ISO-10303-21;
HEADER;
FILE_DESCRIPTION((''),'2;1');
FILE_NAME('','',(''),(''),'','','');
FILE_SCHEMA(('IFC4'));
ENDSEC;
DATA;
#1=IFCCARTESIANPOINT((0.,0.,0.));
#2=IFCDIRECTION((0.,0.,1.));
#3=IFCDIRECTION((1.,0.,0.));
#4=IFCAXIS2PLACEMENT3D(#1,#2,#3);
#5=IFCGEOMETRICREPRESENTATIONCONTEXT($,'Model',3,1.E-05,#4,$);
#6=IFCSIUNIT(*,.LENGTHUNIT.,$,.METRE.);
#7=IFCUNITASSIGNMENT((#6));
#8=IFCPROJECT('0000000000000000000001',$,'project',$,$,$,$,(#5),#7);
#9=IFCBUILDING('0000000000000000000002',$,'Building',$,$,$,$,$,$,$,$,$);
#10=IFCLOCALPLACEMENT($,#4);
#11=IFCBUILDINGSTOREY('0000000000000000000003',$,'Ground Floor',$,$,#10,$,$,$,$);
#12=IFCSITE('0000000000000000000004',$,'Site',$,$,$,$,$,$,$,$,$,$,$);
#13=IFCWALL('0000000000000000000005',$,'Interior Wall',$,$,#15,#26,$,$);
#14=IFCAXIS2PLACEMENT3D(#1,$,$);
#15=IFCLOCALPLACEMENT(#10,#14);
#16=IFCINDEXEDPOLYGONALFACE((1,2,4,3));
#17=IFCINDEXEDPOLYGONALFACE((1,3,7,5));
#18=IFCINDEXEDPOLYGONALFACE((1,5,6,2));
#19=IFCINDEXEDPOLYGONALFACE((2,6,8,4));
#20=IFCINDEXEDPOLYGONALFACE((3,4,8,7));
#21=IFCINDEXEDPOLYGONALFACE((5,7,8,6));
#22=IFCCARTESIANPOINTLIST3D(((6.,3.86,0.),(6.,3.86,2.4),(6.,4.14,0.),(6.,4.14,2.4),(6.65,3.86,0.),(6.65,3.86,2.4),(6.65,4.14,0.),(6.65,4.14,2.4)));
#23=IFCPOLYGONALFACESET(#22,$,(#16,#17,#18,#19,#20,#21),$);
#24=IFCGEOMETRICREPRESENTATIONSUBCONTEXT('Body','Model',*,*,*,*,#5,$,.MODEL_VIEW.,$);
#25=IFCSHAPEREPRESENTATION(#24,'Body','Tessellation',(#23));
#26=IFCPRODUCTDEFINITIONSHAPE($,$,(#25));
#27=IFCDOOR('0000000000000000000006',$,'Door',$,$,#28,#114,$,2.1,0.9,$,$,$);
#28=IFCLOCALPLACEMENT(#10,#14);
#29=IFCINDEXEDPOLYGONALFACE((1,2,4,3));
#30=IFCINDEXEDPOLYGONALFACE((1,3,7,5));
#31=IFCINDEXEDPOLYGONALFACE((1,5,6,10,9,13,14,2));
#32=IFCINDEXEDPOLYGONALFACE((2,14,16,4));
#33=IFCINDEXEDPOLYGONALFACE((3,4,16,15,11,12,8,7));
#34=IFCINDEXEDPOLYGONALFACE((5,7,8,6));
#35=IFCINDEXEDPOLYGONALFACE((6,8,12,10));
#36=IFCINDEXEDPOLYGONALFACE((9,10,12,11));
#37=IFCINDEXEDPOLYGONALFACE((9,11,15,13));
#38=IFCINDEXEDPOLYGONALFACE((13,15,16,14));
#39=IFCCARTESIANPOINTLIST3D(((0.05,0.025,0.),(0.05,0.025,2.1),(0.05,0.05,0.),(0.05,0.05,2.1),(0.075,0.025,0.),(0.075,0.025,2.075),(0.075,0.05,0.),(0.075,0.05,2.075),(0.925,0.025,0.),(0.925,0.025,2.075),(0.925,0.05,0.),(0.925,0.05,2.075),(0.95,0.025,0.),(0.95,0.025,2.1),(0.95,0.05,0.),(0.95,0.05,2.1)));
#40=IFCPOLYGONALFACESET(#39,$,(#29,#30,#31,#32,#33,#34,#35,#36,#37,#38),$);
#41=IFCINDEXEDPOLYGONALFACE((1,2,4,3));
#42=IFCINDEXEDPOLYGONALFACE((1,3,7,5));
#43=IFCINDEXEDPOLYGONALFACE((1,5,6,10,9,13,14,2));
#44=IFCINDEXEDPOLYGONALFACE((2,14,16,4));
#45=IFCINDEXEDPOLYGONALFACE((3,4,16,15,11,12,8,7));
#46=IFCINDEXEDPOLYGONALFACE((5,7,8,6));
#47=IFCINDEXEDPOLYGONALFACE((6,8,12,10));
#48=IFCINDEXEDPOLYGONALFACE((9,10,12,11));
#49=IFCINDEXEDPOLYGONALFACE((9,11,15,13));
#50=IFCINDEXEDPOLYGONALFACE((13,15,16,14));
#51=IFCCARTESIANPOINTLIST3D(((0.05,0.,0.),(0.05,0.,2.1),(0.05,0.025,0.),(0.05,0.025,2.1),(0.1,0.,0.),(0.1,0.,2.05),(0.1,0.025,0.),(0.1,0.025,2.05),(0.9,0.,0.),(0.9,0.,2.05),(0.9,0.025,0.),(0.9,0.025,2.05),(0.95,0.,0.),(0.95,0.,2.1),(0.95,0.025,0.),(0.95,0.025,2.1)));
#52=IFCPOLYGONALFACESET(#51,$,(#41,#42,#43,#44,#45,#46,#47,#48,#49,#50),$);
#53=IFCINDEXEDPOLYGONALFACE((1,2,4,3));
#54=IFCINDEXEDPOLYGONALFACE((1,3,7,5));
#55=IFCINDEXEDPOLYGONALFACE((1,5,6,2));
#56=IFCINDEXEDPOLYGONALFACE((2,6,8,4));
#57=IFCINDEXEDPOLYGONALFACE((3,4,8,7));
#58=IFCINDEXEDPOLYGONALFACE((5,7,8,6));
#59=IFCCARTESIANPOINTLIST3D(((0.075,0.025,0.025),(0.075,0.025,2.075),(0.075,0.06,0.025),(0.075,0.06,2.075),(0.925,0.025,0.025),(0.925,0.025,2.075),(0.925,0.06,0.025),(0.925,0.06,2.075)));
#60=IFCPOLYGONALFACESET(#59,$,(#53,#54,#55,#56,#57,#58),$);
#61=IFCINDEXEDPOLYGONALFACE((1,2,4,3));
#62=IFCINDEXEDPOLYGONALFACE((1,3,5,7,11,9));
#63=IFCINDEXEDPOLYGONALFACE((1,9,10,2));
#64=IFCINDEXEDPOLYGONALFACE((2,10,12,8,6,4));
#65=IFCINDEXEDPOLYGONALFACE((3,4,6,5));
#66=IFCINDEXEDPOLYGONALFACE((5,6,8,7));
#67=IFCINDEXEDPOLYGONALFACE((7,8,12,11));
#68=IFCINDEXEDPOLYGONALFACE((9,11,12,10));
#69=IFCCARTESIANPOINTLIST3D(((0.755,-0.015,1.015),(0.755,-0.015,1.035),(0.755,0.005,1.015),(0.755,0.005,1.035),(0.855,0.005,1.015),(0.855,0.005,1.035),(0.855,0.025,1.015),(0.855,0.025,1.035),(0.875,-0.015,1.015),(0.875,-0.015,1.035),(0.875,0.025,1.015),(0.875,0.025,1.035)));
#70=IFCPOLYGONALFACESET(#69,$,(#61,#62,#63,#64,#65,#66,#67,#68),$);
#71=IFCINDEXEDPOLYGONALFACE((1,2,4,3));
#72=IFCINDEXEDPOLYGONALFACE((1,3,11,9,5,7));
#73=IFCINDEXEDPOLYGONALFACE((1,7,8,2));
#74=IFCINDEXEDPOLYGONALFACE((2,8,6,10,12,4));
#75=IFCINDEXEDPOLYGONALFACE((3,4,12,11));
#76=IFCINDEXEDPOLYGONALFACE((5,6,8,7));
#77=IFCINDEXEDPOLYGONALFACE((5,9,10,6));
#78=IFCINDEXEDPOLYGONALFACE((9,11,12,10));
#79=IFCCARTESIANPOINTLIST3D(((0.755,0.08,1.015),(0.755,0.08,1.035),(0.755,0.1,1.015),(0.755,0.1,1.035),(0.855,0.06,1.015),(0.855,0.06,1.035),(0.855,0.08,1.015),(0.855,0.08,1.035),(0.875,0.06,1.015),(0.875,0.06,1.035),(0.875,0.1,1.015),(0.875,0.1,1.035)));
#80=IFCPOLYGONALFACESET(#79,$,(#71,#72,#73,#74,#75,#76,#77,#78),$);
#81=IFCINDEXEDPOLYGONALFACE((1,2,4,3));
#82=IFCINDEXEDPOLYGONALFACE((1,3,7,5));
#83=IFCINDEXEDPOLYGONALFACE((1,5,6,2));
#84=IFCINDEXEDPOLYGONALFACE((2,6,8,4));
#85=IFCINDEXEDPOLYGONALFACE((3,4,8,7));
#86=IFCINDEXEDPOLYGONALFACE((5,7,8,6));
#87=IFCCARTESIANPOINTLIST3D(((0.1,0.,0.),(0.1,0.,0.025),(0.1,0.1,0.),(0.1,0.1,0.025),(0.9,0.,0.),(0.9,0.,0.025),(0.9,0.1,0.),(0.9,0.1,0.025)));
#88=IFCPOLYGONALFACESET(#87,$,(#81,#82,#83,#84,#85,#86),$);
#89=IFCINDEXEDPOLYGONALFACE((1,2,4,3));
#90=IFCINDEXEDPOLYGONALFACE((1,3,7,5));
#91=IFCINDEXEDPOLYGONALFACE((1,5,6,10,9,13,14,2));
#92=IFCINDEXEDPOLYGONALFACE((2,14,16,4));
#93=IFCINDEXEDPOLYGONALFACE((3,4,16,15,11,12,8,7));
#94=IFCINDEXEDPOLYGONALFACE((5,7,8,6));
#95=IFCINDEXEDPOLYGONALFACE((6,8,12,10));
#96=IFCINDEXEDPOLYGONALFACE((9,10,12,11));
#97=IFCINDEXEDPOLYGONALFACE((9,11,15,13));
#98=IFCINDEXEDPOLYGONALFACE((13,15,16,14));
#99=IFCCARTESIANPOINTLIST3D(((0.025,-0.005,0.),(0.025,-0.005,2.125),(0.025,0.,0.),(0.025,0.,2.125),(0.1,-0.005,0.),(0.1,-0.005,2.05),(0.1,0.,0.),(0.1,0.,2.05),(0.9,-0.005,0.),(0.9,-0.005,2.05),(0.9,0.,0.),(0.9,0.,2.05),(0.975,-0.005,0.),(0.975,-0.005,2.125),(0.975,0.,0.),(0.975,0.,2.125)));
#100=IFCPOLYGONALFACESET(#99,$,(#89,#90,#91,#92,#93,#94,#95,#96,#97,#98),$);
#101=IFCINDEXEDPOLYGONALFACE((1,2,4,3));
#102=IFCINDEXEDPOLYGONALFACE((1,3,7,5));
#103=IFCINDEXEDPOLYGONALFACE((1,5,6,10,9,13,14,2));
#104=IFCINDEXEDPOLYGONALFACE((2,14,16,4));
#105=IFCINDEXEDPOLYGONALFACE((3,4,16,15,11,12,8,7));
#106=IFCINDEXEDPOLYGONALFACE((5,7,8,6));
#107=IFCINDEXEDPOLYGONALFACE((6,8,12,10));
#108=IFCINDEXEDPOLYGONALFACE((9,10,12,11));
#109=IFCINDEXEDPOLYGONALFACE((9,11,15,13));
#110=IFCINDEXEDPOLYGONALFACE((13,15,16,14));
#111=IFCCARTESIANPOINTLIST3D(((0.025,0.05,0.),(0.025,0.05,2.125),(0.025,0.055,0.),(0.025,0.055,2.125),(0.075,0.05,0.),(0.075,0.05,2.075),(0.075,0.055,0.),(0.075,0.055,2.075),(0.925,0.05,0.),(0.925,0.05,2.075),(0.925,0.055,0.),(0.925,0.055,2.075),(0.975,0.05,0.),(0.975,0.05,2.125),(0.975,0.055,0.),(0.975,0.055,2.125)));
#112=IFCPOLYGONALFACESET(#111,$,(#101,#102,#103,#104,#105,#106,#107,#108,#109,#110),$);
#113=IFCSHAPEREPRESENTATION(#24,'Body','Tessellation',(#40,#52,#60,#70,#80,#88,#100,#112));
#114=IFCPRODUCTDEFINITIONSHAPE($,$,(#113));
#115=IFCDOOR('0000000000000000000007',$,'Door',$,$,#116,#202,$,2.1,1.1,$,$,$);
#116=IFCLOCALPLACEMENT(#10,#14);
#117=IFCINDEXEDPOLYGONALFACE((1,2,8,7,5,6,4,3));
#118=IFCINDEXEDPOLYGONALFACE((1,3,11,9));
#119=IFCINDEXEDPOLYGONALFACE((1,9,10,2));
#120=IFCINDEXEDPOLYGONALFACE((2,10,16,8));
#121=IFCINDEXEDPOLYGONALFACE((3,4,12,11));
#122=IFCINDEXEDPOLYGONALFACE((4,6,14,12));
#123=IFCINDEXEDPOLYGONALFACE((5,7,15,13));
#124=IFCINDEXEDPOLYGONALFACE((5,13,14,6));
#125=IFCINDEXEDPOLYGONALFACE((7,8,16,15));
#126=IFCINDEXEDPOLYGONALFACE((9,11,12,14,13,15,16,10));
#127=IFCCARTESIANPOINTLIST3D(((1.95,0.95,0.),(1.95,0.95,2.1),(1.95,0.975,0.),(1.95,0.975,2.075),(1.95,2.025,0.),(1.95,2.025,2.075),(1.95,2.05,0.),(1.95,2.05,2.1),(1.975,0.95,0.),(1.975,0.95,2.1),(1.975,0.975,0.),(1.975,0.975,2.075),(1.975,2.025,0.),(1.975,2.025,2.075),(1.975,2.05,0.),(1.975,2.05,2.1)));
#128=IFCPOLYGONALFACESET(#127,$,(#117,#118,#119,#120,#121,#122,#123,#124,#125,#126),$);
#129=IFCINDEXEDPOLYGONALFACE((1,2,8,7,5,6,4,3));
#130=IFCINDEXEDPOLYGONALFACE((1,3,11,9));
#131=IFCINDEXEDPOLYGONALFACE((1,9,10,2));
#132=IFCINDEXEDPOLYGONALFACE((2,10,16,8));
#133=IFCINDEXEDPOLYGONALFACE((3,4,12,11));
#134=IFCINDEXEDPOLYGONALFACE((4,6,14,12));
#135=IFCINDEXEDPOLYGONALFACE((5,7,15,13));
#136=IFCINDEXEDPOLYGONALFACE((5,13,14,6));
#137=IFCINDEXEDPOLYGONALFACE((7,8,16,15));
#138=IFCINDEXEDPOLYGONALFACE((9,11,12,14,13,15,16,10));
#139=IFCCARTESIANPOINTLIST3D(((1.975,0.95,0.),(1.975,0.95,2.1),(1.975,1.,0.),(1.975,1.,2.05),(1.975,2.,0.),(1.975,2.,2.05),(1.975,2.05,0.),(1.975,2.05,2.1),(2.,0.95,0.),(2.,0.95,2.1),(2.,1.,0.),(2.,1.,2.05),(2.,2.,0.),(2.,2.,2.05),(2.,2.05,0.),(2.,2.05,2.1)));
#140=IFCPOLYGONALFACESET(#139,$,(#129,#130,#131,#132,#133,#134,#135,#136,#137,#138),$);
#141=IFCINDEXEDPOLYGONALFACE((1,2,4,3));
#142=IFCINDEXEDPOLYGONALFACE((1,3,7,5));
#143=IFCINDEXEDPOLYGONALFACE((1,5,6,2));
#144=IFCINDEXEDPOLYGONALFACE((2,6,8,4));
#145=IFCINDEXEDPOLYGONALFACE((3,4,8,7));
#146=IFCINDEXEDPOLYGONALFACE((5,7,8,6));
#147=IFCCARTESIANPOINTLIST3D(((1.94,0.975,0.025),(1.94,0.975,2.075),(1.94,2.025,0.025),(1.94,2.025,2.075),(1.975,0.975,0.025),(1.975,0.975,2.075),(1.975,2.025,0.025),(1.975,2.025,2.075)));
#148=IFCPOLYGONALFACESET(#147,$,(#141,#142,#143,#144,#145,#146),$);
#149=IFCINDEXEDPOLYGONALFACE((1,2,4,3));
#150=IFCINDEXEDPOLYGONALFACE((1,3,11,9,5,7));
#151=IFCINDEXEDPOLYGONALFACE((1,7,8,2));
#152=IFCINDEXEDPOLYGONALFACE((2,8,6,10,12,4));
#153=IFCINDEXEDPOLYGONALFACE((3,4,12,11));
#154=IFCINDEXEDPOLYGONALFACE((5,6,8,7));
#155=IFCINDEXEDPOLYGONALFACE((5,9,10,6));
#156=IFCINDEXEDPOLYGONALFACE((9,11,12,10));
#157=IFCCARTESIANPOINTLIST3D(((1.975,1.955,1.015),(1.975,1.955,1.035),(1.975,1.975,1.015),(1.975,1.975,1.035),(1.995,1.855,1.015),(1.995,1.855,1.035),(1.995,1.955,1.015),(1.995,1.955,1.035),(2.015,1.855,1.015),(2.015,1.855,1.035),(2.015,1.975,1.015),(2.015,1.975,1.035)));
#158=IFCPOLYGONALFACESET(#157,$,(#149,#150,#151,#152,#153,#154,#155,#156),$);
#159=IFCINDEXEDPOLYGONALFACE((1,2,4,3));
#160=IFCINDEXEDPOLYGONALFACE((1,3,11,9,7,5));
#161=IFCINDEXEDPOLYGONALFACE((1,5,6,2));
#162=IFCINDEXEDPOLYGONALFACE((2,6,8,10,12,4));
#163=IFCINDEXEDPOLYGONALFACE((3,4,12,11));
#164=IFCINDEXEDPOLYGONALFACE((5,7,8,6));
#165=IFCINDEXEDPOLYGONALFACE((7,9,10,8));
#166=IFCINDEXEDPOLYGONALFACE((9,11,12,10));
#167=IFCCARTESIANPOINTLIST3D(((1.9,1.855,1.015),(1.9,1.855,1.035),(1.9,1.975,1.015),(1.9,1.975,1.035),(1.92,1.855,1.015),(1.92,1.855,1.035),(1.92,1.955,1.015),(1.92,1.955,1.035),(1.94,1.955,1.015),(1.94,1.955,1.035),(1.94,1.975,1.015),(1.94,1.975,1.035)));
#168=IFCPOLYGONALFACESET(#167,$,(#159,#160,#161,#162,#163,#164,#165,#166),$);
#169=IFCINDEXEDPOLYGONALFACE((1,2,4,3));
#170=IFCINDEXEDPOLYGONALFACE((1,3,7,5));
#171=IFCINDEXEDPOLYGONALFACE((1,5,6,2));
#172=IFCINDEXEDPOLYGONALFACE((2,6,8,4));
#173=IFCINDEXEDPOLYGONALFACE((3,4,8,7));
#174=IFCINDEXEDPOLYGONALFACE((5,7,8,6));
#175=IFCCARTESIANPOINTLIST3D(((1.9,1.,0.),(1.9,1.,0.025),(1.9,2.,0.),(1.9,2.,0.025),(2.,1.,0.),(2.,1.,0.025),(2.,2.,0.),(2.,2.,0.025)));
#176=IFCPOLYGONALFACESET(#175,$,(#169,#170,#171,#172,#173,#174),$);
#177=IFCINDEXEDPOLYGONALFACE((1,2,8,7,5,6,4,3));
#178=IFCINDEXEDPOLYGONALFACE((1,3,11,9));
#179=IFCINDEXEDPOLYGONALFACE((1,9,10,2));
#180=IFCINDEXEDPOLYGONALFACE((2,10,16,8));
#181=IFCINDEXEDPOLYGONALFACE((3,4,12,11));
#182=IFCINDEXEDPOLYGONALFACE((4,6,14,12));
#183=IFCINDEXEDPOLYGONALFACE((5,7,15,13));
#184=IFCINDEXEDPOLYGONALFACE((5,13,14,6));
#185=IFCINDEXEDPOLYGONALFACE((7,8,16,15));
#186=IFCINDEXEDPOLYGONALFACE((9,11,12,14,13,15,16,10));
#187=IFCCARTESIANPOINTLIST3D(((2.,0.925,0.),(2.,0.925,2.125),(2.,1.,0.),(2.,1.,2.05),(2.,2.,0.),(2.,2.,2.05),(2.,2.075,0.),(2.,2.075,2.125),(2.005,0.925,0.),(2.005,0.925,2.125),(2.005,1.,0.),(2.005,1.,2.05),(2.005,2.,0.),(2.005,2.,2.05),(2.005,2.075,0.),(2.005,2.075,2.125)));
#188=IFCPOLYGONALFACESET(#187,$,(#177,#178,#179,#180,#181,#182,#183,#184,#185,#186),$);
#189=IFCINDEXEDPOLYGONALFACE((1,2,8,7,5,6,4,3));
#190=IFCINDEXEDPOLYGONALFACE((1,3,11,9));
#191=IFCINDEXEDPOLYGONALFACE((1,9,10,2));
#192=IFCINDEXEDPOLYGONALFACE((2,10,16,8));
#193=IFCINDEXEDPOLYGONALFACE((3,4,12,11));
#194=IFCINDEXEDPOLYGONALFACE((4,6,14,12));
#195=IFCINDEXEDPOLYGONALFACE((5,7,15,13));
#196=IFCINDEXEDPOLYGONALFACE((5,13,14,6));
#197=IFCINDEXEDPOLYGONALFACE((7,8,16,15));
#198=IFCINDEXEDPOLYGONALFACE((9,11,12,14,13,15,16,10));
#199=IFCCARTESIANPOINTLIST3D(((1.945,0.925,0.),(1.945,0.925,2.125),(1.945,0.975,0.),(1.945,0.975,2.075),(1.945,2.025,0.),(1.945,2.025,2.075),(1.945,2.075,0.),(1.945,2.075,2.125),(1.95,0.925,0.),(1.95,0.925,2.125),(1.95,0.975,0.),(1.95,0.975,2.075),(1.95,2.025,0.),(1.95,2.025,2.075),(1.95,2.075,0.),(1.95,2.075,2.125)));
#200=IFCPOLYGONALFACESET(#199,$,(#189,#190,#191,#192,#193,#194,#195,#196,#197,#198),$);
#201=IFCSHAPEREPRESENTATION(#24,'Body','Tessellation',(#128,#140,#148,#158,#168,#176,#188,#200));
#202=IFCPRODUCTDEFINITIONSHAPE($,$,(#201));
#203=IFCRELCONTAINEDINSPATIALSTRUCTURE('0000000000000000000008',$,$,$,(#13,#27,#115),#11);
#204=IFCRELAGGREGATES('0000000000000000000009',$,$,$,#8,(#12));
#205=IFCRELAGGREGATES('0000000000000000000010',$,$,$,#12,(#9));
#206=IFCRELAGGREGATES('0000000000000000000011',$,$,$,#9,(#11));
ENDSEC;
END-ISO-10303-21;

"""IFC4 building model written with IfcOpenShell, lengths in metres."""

from ifc_helpers import new_model, si_unit, frame, origin_with_axes, place, context, subcontext, project, spatial, line, indexed_curve, outline, extrude, element, save


model = new_model("IFC4")

# Units and contexts
model_context = context("Model", 3, precision=1e-05, world=origin_with_axes())
body_context = subcontext(model_context, "Body", "Model", "MODEL_VIEW")
ifc_project = project(units=[si_unit("LENGTHUNIT", "METRE")], contexts=[model_context])

# Site, building, storey
site = spatial("IfcSite", under=ifc_project, Name="Site")
building = spatial("IfcBuilding", under=site, Name="Building")
storey_placement = place(None, origin_with_axes())
storey = spatial("IfcBuildingStorey", under=building, at=storey_placement, Name="Ground Floor")

# Wall
for number, where, z_axis, x_axis, name in (
    (1, (6.65, 4.0, 0.0), (0.0, 0.0, 1.0), (-1.0, 0.0, 0.0), "Interior Wall"),
):
    element("IfcWall", number, at=place(storey_placement, frame(where, z_axis=z_axis, x_axis=x_axis)), inside=storey, Name=name, context=body_context, shape_type="SweptSolid", body=[
        extrude(outline(indexed_curve([(0.0, 0.0), (0.0, 0.28), (0.65, 0.28), (0.65, 0.0), (0.0, 0.0)], self_intersect=False)), frame((0.0, -0.14, 0.0), z_axis=(0.0, 0.0, 1.0), x_axis=(1.0, 0.0, 0.0)), (0.0, 0.0, 1.0), 2.4),
    ])

# Doors
door_1_placement = place(storey_placement, frame((0.05, 0.0, 0.0), z_axis=(0.0, 0.0, 1.0), x_axis=(1.0, 0.0, 0.0)))
element("IfcDoor", 2, at=door_1_placement, inside=storey, Name="Door", OverallHeight=2.1, OverallWidth=0.9, context=body_context, shape_type="SweptSolid", body=[
    extrude(outline(indexed_curve([(0.0, 0.0), (0.0, 2.1), (0.9, 2.1), (0.9, 0.0), (0.875, 0.0), (0.875, 2.075), (0.025, 2.075), (0.025, 0.0)], segments=[line(1, 2, 3, 4, 5, 6, 7, 8, 1)])), frame((0.0, 0.025, 0.0), z_axis=(0.0, -1.0, 0.0), x_axis=(1.0, 0.0, 0.0)), (0.0, 0.0, -1.0), 0.025),
    extrude(outline(indexed_curve([(0.0, 0.0), (0.0, 2.1), (0.9, 2.1), (0.9, 0.0), (0.85, 0.0), (0.85, 2.05), (0.05, 2.05), (0.05, 0.0)], segments=[line(1, 2, 3, 4, 5, 6, 7, 8, 1)])), frame((0.0, 0.0, 0.0), z_axis=(0.0, -1.0, 0.0), x_axis=(1.0, 0.0, 0.0)), (0.0, 0.0, -1.0), 0.025),
    extrude(outline(indexed_curve([(0.0, 0.0), (0.85, 0.0), (0.85, 0.035), (0.0, 0.035)], segments=[line(1, 2, 3, 4, 1)])), frame((0.025, 0.025, 0.025), z_axis=(0.0, 0.0, 1.0), x_axis=(1.0, 0.0, 0.0)), (0.0, 0.0, 1.0), 2.05),
    extrude(outline(indexed_curve([(0.0, 0.0), (0.0, -0.04), (-0.12, -0.04), (-0.12, -0.02), (-0.02, -0.02), (-0.02, 0.0)], segments=[line(1, 2, 3, 4, 5, 6, 1)])), frame((0.825, 0.025, 1.015), z_axis=(0.0, 0.0, 1.0), x_axis=(1.0, 0.0, 0.0)), (0.0, 0.0, 1.0), 0.02),
    extrude(outline(indexed_curve([(0.0, 0.0), (0.0, 0.04), (-0.12, 0.04), (-0.12, 0.02), (-0.02, 0.02), (-0.02, 0.0)], segments=[line(1, 2, 3, 4, 5, 6, 1)])), frame((0.825, 0.06, 1.015), z_axis=(0.0, 0.0, 1.0), x_axis=(1.0, 0.0, 0.0)), (0.0, 0.0, 1.0), 0.02),
    extrude(outline(indexed_curve([(0.0, 0.0), (0.8, 0.0), (0.8, 0.1), (0.0, 0.1)], segments=[line(1, 2, 3, 4, 1)])), frame((0.05, 0.0, 0.0), z_axis=(0.0, 0.0, 1.0), x_axis=(1.0, 0.0, 0.0)), (0.0, 0.0, 1.0), 0.025),
    extrude(outline(indexed_curve([(0.0, 0.0), (0.0, 2.125), (0.95, 2.125), (0.95, 0.0), (0.875, 0.0), (0.875, 2.05), (0.075, 2.05), (0.075, 0.0)], segments=[line(1, 2, 3, 4, 5, 6, 7, 8, 1)])), frame((-0.025, -0.005, 0.0), z_axis=(0.0, -1.0, 0.0), x_axis=(1.0, 0.0, 0.0)), (0.0, 0.0, -1.0), 0.005),
    extrude(outline(indexed_curve([(0.0, 0.0), (0.0, 2.125), (0.95, 2.125), (0.95, 0.0), (0.9, 0.0), (0.9, 2.075), (0.05, 2.075), (0.05, 0.0)], segments=[line(1, 2, 3, 4, 5, 6, 7, 8, 1)])), frame((-0.025, 0.05, 0.0), z_axis=(0.0, -1.0, 0.0), x_axis=(1.0, 0.0, 0.0)), (0.0, 0.0, -1.0), 0.005),
])
door_2_placement = place(storey_placement, frame((2.0, 0.95, 0.0), z_axis=(0.0, 0.0, 1.0), x_axis=(0.0, 1.0, 0.0)))
element("IfcDoor", 3, at=door_2_placement, inside=storey, Name="Door", OverallHeight=2.1, OverallWidth=1.1, context=body_context, shape_type="SweptSolid", body=[
    extrude(outline(indexed_curve([(0.0, 0.0), (0.0, 2.1), (1.1, 2.1), (1.1, 0.0), (1.075, 0.0), (1.075, 2.075), (0.025, 2.075), (0.025, 0.0)], segments=[line(1, 2, 3, 4, 5, 6, 7, 8, 1)])), frame((0.0, 0.025, 0.0), z_axis=(0.0, -1.0, 0.0), x_axis=(1.0, 0.0, 0.0)), (0.0, 0.0, -1.0), 0.025),
    extrude(outline(indexed_curve([(0.0, 0.0), (0.0, 2.1), (1.1, 2.1), (1.1, 0.0), (1.05, 0.0), (1.05, 2.05), (0.05, 2.05), (0.05, 0.0)], segments=[line(1, 2, 3, 4, 5, 6, 7, 8, 1)])), frame((0.0, 0.0, 0.0), z_axis=(0.0, -1.0, 0.0), x_axis=(1.0, 0.0, 0.0)), (0.0, 0.0, -1.0), 0.025),
    extrude(outline(indexed_curve([(0.0, 0.0), (1.05, 0.0), (1.05, 0.035), (0.0, 0.035)], segments=[line(1, 2, 3, 4, 1)])), frame((0.025, 0.025, 0.025), z_axis=(0.0, 0.0, 1.0), x_axis=(1.0, 0.0, 0.0)), (0.0, 0.0, 1.0), 2.05),
    extrude(outline(indexed_curve([(0.0, 0.0), (0.0, -0.04), (-0.12, -0.04), (-0.12, -0.02), (-0.02, -0.02), (-0.02, 0.0)], segments=[line(1, 2, 3, 4, 5, 6, 1)])), frame((1.025, 0.025, 1.015), z_axis=(0.0, 0.0, 1.0), x_axis=(1.0, 0.0, 0.0)), (0.0, 0.0, 1.0), 0.02),
    extrude(outline(indexed_curve([(0.0, 0.0), (0.0, 0.04), (-0.12, 0.04), (-0.12, 0.02), (-0.02, 0.02), (-0.02, 0.0)], segments=[line(1, 2, 3, 4, 5, 6, 1)])), frame((1.025, 0.06, 1.015), z_axis=(0.0, 0.0, 1.0), x_axis=(1.0, 0.0, 0.0)), (0.0, 0.0, 1.0), 0.02),
    extrude(outline(indexed_curve([(0.0, 0.0), (1.0, 0.0), (1.0, 0.1), (0.0, 0.1)], segments=[line(1, 2, 3, 4, 1)])), frame((0.05, 0.0, 0.0), z_axis=(0.0, 0.0, 1.0), x_axis=(1.0, 0.0, 0.0)), (0.0, 0.0, 1.0), 0.025),
    extrude(outline(indexed_curve([(0.0, 0.0), (0.0, 2.125), (1.15, 2.125), (1.15, 0.0), (1.075, 0.0), (1.075, 2.05), (0.075, 2.05), (0.075, 0.0)], segments=[line(1, 2, 3, 4, 5, 6, 7, 8, 1)])), frame((-0.025, -0.005, 0.0), z_axis=(0.0, -1.0, 0.0), x_axis=(1.0, 0.0, 0.0)), (0.0, 0.0, -1.0), 0.005),
    extrude(outline(indexed_curve([(0.0, 0.0), (0.0, 2.125), (1.15, 2.125), (1.15, 0.0), (1.1, 0.0), (1.1, 2.075), (0.05, 2.075), (0.05, 0.0)], segments=[line(1, 2, 3, 4, 5, 6, 7, 8, 1)])), frame((-0.025, 0.05, 0.0), z_axis=(0.0, -1.0, 0.0), x_axis=(1.0, 0.0, 0.0)), (0.0, 0.0, -1.0), 0.005),
])

save(model, "model.ifc")
